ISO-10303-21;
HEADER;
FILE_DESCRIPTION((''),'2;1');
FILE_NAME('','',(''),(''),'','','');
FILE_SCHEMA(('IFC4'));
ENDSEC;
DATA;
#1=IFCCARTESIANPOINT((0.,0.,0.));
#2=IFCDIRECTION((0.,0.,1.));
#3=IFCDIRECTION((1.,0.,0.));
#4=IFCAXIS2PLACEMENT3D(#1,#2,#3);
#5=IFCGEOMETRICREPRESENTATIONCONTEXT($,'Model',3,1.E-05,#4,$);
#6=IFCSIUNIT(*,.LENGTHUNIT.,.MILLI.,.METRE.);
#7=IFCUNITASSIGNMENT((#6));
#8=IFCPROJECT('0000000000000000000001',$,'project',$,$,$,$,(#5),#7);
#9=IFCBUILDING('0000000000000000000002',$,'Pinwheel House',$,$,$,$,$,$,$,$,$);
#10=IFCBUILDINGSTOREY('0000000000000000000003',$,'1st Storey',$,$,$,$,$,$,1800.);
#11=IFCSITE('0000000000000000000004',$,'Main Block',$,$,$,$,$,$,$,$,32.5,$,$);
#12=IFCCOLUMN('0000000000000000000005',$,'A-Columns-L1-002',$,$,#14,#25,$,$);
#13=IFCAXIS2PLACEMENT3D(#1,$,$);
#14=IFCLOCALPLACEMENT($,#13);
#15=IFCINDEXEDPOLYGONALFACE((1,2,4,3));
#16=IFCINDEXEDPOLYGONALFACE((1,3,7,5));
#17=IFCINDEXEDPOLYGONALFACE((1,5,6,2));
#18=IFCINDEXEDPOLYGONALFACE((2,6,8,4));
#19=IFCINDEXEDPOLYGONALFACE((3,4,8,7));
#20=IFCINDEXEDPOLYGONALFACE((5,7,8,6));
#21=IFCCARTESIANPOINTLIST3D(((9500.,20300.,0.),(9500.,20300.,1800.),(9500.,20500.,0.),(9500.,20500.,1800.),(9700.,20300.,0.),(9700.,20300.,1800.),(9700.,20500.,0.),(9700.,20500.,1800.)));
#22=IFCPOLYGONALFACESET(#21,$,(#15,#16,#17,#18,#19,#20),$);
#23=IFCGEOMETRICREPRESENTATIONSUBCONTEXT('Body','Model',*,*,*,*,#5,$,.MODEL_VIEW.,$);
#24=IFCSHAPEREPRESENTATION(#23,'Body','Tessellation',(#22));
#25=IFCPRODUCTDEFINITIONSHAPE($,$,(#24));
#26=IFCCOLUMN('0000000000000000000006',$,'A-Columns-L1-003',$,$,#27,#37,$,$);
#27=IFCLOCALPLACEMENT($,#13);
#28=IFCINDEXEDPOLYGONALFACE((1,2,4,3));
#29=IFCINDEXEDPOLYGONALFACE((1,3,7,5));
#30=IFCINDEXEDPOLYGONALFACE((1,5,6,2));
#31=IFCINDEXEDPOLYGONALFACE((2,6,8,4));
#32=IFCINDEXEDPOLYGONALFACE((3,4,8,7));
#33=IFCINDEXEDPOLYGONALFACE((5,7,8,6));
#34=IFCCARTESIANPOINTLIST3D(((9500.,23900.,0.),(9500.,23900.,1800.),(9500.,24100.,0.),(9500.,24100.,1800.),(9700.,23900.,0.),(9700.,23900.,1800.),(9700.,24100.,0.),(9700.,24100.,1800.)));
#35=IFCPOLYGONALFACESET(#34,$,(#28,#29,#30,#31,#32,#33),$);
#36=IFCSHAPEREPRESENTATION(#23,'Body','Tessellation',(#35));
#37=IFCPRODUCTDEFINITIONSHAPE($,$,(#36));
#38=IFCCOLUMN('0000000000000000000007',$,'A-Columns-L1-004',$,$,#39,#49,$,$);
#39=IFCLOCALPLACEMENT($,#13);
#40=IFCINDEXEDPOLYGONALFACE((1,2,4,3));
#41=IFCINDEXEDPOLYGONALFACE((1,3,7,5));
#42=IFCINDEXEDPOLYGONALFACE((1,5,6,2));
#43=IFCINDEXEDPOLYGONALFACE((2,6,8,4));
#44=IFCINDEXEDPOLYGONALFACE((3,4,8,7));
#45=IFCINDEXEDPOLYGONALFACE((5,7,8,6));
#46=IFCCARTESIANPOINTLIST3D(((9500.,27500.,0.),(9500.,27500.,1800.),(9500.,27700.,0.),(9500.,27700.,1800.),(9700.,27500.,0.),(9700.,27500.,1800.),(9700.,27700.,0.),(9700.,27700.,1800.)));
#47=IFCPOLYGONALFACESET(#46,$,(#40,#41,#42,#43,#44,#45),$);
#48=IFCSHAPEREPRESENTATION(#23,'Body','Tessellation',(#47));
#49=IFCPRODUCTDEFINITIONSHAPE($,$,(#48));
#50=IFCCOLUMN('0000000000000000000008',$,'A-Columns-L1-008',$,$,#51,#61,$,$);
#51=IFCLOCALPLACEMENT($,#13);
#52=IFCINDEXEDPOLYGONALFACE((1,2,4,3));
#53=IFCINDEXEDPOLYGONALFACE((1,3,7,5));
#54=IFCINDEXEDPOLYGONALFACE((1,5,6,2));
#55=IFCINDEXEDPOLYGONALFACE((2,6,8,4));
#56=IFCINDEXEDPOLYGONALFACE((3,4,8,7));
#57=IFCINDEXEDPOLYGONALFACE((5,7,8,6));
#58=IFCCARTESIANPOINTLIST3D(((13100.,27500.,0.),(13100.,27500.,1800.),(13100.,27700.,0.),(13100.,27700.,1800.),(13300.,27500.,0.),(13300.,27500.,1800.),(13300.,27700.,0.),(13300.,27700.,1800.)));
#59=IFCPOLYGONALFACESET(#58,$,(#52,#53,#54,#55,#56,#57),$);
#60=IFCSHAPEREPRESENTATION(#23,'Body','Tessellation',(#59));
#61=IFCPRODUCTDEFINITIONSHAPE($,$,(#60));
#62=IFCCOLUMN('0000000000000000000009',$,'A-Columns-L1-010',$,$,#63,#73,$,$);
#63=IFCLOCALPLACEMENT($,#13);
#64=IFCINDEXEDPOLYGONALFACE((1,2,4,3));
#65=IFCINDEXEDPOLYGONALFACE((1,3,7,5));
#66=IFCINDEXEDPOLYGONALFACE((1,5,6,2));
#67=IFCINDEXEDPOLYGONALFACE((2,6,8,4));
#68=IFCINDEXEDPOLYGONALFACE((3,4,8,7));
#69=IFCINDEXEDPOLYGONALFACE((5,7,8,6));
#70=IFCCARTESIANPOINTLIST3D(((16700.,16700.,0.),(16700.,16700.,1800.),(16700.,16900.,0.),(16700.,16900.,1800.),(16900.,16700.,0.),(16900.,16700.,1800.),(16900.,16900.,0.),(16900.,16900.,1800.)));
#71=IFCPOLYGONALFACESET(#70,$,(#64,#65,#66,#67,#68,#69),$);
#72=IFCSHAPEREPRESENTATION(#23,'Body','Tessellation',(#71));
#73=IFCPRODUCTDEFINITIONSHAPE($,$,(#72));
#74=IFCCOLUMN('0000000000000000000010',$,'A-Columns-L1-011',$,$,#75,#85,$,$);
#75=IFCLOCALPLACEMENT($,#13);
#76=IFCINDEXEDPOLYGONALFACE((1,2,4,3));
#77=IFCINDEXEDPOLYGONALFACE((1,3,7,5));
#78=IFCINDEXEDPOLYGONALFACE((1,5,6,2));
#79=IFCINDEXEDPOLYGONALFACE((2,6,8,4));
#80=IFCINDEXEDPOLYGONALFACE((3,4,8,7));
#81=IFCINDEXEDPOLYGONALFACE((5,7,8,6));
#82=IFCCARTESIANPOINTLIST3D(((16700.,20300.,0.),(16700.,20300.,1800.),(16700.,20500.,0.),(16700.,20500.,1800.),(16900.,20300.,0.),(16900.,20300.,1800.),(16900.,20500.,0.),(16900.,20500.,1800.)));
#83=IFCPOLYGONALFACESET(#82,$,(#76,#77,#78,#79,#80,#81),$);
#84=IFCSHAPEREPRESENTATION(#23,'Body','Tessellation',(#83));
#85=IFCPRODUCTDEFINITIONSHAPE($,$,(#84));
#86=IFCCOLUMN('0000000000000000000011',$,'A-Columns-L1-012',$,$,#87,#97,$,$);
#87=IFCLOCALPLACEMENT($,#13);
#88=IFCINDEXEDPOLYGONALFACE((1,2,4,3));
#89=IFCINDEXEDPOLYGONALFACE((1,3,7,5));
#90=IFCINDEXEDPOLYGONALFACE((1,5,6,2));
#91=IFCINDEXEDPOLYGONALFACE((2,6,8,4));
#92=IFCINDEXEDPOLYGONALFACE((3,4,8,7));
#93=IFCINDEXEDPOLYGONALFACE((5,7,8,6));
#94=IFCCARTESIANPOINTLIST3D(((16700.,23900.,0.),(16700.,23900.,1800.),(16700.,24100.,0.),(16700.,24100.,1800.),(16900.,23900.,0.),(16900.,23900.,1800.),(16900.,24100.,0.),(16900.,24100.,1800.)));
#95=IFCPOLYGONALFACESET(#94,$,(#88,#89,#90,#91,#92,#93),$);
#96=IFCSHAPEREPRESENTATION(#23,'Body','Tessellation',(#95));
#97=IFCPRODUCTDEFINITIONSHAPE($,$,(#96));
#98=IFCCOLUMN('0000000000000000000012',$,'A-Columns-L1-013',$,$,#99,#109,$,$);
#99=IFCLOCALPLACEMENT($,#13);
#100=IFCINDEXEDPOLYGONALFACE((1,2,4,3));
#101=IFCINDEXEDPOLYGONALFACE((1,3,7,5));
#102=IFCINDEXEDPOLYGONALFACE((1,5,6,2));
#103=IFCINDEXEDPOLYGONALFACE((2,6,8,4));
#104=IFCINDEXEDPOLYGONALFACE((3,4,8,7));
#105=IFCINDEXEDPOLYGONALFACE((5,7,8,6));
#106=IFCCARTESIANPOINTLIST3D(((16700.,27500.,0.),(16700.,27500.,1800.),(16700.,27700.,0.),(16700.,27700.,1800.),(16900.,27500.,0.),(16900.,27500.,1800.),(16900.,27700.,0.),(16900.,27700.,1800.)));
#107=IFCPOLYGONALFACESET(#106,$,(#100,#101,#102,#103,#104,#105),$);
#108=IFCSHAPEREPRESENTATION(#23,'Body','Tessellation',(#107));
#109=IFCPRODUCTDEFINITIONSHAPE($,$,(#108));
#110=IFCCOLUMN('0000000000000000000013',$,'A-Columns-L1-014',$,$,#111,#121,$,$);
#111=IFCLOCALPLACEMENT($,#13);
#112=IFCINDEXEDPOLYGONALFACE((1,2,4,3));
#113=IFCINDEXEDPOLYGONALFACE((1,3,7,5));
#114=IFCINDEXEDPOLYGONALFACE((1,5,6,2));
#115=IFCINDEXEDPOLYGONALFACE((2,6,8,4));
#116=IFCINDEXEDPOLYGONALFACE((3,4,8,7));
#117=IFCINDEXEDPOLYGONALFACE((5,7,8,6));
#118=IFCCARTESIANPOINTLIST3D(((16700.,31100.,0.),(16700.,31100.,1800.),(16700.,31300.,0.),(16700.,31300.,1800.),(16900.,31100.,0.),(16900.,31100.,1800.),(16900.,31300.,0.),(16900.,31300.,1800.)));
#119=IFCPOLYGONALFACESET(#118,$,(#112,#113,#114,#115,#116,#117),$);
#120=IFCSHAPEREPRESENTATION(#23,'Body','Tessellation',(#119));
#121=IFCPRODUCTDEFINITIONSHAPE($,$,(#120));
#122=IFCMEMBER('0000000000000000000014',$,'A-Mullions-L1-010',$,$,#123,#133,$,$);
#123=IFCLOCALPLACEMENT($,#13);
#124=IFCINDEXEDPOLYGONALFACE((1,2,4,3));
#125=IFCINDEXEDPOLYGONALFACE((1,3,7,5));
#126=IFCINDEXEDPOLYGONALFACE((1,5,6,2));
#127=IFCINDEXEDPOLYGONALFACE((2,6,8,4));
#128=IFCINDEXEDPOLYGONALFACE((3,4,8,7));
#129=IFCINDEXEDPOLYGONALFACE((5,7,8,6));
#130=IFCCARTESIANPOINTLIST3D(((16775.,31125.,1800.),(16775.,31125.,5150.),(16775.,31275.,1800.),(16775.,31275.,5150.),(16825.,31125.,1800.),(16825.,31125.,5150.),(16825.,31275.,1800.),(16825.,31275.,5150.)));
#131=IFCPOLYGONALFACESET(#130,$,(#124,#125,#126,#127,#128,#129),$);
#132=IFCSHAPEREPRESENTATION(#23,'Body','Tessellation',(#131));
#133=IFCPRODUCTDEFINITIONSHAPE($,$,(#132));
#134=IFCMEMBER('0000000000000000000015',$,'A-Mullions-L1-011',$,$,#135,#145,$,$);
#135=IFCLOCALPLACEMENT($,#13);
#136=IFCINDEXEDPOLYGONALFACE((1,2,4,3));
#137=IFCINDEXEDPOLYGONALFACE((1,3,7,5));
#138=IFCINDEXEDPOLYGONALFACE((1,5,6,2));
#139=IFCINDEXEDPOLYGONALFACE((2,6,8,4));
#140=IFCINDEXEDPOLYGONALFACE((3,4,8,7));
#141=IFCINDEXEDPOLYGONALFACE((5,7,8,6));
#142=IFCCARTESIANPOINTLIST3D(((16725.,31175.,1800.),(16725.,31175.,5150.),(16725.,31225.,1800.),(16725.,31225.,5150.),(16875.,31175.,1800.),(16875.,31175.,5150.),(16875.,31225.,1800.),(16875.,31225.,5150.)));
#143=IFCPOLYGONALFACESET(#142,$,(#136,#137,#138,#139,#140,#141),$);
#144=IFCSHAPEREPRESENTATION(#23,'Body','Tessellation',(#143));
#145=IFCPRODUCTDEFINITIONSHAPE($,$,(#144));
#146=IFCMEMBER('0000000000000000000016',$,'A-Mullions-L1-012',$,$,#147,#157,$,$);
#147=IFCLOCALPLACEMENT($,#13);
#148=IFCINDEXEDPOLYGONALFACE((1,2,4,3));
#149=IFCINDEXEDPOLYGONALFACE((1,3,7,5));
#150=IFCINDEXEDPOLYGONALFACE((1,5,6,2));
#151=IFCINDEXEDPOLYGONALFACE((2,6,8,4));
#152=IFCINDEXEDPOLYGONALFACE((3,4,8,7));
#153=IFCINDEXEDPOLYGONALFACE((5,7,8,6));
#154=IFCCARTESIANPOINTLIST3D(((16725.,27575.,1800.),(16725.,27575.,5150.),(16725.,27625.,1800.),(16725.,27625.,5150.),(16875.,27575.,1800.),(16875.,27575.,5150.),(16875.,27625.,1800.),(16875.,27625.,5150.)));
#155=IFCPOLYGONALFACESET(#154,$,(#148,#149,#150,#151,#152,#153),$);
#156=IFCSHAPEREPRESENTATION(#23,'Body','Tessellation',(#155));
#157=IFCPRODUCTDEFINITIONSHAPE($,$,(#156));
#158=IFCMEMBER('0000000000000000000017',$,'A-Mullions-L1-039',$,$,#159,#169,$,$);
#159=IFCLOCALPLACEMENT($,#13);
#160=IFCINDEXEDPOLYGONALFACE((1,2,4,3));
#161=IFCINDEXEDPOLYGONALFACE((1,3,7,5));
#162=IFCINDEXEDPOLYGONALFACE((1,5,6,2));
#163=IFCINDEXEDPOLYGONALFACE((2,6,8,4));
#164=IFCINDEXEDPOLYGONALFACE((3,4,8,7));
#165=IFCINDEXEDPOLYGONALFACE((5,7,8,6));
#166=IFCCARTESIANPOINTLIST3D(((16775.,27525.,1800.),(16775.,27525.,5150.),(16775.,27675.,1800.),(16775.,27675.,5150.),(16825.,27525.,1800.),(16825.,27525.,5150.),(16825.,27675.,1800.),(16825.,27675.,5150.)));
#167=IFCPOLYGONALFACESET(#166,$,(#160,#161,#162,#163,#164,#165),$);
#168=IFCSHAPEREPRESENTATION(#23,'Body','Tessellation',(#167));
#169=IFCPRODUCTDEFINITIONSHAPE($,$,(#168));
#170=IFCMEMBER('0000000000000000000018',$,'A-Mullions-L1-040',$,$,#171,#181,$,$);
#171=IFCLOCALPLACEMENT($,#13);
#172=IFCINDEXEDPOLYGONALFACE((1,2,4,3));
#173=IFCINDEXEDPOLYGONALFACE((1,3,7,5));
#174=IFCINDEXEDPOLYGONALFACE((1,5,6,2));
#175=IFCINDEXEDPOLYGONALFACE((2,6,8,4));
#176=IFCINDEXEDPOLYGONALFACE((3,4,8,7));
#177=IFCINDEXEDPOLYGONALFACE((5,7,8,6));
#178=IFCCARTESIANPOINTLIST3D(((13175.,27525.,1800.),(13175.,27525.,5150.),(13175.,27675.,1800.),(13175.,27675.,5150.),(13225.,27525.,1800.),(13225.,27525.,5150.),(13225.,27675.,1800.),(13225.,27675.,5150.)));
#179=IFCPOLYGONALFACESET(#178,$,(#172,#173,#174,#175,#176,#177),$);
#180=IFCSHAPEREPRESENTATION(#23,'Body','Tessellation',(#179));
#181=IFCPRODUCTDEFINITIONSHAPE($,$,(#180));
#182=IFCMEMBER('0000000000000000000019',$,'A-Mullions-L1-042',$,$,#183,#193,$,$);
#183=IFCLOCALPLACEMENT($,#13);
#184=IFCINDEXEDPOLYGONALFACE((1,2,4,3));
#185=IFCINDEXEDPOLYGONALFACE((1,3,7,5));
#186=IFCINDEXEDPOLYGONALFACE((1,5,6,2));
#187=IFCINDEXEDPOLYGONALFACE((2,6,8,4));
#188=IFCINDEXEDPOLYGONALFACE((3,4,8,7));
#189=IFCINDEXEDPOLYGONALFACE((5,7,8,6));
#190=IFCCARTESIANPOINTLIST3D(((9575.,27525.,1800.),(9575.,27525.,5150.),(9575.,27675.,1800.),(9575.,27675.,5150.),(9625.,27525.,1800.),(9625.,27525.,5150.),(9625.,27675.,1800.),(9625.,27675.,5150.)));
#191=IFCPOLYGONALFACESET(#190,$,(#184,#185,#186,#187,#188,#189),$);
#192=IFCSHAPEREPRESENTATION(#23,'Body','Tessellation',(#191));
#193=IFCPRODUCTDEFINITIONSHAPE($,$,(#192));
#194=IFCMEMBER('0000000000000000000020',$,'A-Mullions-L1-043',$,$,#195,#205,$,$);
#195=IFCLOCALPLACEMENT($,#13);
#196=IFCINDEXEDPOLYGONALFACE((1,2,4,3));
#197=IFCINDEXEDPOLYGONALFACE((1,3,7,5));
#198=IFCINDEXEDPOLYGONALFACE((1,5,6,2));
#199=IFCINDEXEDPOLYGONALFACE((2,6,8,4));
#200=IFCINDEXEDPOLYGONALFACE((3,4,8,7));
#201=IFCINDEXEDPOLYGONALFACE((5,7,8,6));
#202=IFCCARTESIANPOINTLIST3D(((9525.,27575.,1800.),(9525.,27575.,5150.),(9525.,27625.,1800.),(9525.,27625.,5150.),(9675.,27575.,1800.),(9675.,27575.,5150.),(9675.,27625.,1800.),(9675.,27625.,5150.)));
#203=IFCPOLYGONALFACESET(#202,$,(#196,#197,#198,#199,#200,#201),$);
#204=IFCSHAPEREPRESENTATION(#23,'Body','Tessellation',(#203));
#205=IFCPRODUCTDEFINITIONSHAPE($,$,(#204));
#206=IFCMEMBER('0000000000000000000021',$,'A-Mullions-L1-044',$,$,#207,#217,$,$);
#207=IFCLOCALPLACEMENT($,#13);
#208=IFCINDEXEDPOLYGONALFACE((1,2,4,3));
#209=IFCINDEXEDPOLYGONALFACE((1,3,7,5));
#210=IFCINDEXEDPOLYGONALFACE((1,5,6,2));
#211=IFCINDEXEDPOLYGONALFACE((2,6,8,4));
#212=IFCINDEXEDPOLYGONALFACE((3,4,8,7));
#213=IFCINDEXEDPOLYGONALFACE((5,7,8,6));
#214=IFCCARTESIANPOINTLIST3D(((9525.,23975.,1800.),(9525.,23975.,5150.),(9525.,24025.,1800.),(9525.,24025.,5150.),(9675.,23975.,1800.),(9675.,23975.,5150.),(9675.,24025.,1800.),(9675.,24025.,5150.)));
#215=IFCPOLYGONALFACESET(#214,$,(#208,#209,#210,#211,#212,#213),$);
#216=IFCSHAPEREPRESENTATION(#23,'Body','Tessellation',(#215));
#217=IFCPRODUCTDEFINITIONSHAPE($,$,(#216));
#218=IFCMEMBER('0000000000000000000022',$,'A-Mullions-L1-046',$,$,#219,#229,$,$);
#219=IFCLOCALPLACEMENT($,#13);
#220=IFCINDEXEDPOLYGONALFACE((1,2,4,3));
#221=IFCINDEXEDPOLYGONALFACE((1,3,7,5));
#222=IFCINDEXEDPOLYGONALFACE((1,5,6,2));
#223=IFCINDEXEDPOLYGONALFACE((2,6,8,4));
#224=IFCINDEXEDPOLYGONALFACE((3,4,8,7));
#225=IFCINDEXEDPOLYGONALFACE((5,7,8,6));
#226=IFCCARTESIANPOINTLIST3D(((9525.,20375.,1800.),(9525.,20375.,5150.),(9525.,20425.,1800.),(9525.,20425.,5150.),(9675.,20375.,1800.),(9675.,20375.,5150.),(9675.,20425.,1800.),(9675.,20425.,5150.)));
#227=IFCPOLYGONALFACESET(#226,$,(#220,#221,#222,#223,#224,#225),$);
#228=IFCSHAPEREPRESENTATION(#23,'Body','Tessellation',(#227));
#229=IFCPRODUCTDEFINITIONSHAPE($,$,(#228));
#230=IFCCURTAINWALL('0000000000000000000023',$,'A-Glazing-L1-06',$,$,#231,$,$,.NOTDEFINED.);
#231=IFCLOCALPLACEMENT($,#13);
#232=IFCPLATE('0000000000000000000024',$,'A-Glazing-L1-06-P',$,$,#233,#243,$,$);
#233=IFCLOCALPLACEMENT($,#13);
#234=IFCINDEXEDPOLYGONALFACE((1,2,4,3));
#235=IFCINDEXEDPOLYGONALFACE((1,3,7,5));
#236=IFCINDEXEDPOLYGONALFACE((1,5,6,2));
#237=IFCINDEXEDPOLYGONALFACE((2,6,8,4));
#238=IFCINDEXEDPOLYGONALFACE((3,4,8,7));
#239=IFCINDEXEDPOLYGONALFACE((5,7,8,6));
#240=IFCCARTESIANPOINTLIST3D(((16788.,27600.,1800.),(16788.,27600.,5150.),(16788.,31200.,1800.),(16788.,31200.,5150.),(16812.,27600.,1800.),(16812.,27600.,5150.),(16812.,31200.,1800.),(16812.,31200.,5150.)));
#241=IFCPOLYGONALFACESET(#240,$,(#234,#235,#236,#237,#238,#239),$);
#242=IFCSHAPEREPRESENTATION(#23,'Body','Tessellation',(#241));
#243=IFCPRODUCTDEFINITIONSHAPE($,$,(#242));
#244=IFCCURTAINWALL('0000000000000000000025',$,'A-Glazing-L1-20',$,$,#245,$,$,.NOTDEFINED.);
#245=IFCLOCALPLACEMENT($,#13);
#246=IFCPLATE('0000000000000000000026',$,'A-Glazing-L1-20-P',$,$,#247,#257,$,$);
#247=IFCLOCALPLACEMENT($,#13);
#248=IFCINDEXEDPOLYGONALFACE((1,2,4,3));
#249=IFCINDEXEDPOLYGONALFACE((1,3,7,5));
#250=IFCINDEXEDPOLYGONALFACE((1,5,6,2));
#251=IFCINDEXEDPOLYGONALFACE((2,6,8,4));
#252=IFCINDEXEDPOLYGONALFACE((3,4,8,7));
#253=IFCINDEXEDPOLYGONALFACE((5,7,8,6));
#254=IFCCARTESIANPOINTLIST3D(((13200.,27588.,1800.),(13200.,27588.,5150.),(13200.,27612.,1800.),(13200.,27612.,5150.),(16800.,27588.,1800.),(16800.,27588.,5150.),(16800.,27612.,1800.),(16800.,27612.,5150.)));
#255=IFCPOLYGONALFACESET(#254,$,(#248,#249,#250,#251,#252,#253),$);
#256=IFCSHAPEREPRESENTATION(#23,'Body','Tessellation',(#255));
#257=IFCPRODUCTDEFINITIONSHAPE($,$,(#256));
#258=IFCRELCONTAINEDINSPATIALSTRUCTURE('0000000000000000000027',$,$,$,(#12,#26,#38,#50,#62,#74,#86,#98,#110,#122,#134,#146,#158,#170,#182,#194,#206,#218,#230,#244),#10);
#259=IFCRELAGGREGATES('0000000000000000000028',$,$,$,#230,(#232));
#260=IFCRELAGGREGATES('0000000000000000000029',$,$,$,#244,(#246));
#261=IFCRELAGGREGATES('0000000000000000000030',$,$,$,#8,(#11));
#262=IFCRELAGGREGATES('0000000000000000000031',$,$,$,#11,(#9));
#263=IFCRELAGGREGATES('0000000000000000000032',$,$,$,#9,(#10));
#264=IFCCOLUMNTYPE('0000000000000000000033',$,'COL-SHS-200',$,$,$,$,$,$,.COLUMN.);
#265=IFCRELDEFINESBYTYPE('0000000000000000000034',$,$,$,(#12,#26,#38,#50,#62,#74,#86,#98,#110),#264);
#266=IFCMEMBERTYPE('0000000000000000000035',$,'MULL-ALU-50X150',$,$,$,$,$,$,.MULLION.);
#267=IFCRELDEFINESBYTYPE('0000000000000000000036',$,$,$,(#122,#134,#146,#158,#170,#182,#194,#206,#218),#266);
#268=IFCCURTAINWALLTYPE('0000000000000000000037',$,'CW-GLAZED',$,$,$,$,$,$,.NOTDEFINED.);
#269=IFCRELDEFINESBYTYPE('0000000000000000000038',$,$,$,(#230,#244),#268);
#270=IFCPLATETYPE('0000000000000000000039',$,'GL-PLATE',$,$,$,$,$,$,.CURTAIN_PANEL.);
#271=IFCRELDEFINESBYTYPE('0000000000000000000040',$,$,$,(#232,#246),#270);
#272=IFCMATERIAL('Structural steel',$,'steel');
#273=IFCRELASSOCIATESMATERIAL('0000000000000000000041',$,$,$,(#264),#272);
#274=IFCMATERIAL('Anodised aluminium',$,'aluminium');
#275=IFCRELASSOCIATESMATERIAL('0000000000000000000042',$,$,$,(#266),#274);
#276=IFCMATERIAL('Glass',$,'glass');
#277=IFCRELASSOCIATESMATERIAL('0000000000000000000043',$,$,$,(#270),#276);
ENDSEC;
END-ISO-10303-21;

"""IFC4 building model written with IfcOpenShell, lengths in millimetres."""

from ifc_helpers import new_model, si_unit, frame, origin_with_axes, place, context, subcontext, project, spatial, indexed_curve, outline, extrude, material, type_object, element, aggregate, save


model = new_model("IFC4")

# Units and contexts
model_context = context("Model", 3, precision=1e-05, world=origin_with_axes())
body_context = subcontext(model_context, "Body", "Model", "MODEL_VIEW")
ifc_project = project(units=[si_unit("LENGTHUNIT", "METRE", prefix="MILLI")], contexts=[model_context])

# Site, building, storey
site = spatial("IfcSite", under=ifc_project, Name="Main Block", RefElevation=32.5)
building = spatial("IfcBuilding", under=site, Name="Pinwheel House")
storey = spatial("IfcBuildingStorey", under=building, Name="1st Storey", Elevation=1800.0)

# Columns
ifc_material_1 = material(Name="Structural steel", Category="steel")
column_type = type_object("IfcColumnType", Name="COL-SHS-200", PredefinedType="COLUMN", material=ifc_material_1)
for number, where, z_axis, x_axis, name in (
    (1, (9600.0, 20400.0, 0.0), (0.0, 0.0, 1.0), (1.0, 0.0, 0.0), "A-Columns-L1-002"),
    (2, (9600.0, 24000.0, 0.0), (0.0, 0.0, 1.0), (1.0, 0.0, 0.0), "A-Columns-L1-003"),
    (3, (9600.0, 27600.0, 0.0), (0.0, 0.0, 1.0), (1.0, 0.0, 0.0), "A-Columns-L1-004"),
    (4, (13200.0, 27600.0, 0.0), (0.0, 0.0, 1.0), (1.0, 0.0, 0.0), "A-Columns-L1-008"),
    (5, (16800.0, 16800.0, 0.0), (0.0, 0.0, 1.0), (1.0, 0.0, 0.0), "A-Columns-L1-010"),
    (6, (16800.0, 20400.0, 0.0), (0.0, 0.0, 1.0), (1.0, 0.0, 0.0), "A-Columns-L1-011"),
    (7, (16800.0, 24000.0, 0.0), (0.0, 0.0, 1.0), (1.0, 0.0, 0.0), "A-Columns-L1-012"),
    (8, (16800.0, 27600.0, 0.0), (0.0, 0.0, 1.0), (1.0, 0.0, 0.0), "A-Columns-L1-013"),
    (9, (16800.0, 31200.0, 0.0), (0.0, 0.0, 1.0), (1.0, 0.0, 0.0), "A-Columns-L1-014"),
):
    element("IfcColumn", number, at=place(None, frame(where, z_axis=z_axis, x_axis=x_axis)), inside=storey, type_object=column_type, Name=name, context=body_context, shape_type="SweptSolid", body=[
        extrude(outline(indexed_curve([(-100.0, -100.0), (100.0, -100.0), (100.0, 100.0), (-100.0, 100.0)])), None, (0.0, 0.0, 1.0), 1800.0),
    ])

# Members
ifc_material_2 = material(Name="Anodised aluminium", Category="aluminium")
member_type = type_object("IfcMemberType", Name="MULL-ALU-50X150", PredefinedType="MULLION", material=ifc_material_2)
for number, where, z_axis, x_axis, name in (
    (10, (16800.0, 31200.0, 1800.0), (0.0, 0.0, 1.0), (-1.0, 0.0, 0.0), "A-Mullions-L1-010"),
    (11, (16800.0, 31200.0, 1800.0), (0.0, 0.0, 1.0), (0.0, -1.0, 0.0), "A-Mullions-L1-011"),
    (12, (16800.0, 27600.0, 1800.0), (0.0, 0.0, 1.0), (0.0, -1.0, 0.0), "A-Mullions-L1-012"),
    (13, (16800.0, 27600.0, 1800.0), (0.0, 0.0, 1.0), (-1.0, 0.0, 0.0), "A-Mullions-L1-039"),
    (14, (13200.0, 27600.0, 1800.0), (0.0, 0.0, 1.0), (-1.0, 0.0, 0.0), "A-Mullions-L1-040"),
    (15, (9600.0, 27600.0, 1800.0), (0.0, 0.0, 1.0), (-1.0, 0.0, 0.0), "A-Mullions-L1-042"),
    (16, (9600.0, 27600.0, 1800.0), (0.0, 0.0, 1.0), (0.0, -1.0, 0.0), "A-Mullions-L1-043"),
    (17, (9600.0, 24000.0, 1800.0), (0.0, 0.0, 1.0), (0.0, -1.0, 0.0), "A-Mullions-L1-044"),
    (18, (9600.0, 20400.0, 1800.0), (0.0, 0.0, 1.0), (0.0, -1.0, 0.0), "A-Mullions-L1-046"),
):
    element("IfcMember", number, at=place(None, frame(where, z_axis=z_axis, x_axis=x_axis)), inside=storey, type_object=member_type, Name=name, context=body_context, shape_type="SweptSolid", body=[
        extrude(outline(indexed_curve([(-25.0, -75.0), (25.0, -75.0), (25.0, 75.0), (-25.0, 75.0)])), None, (0.0, 0.0, 1.0), 3350.0),
    ])

# Curtain walls, plates
curtain_wall_type = type_object("IfcCurtainWallType", Name="CW-GLAZED", PredefinedType="NOTDEFINED")
curtain_wall_1 = element("IfcCurtainWall", 19, inside=storey, type_object=curtain_wall_type, Name="A-Glazing-L1-06", PredefinedType="NOTDEFINED")
ifc_material_3 = material(Name="Glass", Category="glass")
plate_type = type_object("IfcPlateType", Name="GL-PLATE", PredefinedType="CURTAIN_PANEL", material=ifc_material_3)
plate_1_placement = place(None, frame((16800.0, 29400.0, 1800.0), z_axis=(0.0, 0.0, 1.0), x_axis=(0.0, -1.0, 0.0)))
plate_1 = element("IfcPlate", 20, at=plate_1_placement, type_object=plate_type, Name="A-Glazing-L1-06-P", context=body_context, shape_type="SweptSolid", body=[
    extrude(outline(indexed_curve([(-1800.0, -12.0), (1800.0, -12.0), (1800.0, 12.0), (-1800.0, 12.0)])), None, (0.0, 0.0, 1.0), 3350.0),
])
aggregate(curtain_wall_1, [plate_1])
curtain_wall_2 = element("IfcCurtainWall", 21, inside=storey, type_object=curtain_wall_type, Name="A-Glazing-L1-20", PredefinedType="NOTDEFINED")
plate_2_placement = place(None, frame((15000.0, 27600.0, 1800.0), z_axis=(0.0, 0.0, 1.0), x_axis=(-1.0, 0.0, 0.0)))
plate_2 = element("IfcPlate", 22, at=plate_2_placement, type_object=plate_type, Name="A-Glazing-L1-20-P", context=body_context, shape_type="SweptSolid", body=[
    extrude(outline(indexed_curve([(-1800.0, -12.0), (1800.0, -12.0), (1800.0, 12.0), (-1800.0, 12.0)])), None, (0.0, 0.0, 1.0), 3350.0),
])
aggregate(curtain_wall_2, [plate_2])

save(model, "model.ifc")
